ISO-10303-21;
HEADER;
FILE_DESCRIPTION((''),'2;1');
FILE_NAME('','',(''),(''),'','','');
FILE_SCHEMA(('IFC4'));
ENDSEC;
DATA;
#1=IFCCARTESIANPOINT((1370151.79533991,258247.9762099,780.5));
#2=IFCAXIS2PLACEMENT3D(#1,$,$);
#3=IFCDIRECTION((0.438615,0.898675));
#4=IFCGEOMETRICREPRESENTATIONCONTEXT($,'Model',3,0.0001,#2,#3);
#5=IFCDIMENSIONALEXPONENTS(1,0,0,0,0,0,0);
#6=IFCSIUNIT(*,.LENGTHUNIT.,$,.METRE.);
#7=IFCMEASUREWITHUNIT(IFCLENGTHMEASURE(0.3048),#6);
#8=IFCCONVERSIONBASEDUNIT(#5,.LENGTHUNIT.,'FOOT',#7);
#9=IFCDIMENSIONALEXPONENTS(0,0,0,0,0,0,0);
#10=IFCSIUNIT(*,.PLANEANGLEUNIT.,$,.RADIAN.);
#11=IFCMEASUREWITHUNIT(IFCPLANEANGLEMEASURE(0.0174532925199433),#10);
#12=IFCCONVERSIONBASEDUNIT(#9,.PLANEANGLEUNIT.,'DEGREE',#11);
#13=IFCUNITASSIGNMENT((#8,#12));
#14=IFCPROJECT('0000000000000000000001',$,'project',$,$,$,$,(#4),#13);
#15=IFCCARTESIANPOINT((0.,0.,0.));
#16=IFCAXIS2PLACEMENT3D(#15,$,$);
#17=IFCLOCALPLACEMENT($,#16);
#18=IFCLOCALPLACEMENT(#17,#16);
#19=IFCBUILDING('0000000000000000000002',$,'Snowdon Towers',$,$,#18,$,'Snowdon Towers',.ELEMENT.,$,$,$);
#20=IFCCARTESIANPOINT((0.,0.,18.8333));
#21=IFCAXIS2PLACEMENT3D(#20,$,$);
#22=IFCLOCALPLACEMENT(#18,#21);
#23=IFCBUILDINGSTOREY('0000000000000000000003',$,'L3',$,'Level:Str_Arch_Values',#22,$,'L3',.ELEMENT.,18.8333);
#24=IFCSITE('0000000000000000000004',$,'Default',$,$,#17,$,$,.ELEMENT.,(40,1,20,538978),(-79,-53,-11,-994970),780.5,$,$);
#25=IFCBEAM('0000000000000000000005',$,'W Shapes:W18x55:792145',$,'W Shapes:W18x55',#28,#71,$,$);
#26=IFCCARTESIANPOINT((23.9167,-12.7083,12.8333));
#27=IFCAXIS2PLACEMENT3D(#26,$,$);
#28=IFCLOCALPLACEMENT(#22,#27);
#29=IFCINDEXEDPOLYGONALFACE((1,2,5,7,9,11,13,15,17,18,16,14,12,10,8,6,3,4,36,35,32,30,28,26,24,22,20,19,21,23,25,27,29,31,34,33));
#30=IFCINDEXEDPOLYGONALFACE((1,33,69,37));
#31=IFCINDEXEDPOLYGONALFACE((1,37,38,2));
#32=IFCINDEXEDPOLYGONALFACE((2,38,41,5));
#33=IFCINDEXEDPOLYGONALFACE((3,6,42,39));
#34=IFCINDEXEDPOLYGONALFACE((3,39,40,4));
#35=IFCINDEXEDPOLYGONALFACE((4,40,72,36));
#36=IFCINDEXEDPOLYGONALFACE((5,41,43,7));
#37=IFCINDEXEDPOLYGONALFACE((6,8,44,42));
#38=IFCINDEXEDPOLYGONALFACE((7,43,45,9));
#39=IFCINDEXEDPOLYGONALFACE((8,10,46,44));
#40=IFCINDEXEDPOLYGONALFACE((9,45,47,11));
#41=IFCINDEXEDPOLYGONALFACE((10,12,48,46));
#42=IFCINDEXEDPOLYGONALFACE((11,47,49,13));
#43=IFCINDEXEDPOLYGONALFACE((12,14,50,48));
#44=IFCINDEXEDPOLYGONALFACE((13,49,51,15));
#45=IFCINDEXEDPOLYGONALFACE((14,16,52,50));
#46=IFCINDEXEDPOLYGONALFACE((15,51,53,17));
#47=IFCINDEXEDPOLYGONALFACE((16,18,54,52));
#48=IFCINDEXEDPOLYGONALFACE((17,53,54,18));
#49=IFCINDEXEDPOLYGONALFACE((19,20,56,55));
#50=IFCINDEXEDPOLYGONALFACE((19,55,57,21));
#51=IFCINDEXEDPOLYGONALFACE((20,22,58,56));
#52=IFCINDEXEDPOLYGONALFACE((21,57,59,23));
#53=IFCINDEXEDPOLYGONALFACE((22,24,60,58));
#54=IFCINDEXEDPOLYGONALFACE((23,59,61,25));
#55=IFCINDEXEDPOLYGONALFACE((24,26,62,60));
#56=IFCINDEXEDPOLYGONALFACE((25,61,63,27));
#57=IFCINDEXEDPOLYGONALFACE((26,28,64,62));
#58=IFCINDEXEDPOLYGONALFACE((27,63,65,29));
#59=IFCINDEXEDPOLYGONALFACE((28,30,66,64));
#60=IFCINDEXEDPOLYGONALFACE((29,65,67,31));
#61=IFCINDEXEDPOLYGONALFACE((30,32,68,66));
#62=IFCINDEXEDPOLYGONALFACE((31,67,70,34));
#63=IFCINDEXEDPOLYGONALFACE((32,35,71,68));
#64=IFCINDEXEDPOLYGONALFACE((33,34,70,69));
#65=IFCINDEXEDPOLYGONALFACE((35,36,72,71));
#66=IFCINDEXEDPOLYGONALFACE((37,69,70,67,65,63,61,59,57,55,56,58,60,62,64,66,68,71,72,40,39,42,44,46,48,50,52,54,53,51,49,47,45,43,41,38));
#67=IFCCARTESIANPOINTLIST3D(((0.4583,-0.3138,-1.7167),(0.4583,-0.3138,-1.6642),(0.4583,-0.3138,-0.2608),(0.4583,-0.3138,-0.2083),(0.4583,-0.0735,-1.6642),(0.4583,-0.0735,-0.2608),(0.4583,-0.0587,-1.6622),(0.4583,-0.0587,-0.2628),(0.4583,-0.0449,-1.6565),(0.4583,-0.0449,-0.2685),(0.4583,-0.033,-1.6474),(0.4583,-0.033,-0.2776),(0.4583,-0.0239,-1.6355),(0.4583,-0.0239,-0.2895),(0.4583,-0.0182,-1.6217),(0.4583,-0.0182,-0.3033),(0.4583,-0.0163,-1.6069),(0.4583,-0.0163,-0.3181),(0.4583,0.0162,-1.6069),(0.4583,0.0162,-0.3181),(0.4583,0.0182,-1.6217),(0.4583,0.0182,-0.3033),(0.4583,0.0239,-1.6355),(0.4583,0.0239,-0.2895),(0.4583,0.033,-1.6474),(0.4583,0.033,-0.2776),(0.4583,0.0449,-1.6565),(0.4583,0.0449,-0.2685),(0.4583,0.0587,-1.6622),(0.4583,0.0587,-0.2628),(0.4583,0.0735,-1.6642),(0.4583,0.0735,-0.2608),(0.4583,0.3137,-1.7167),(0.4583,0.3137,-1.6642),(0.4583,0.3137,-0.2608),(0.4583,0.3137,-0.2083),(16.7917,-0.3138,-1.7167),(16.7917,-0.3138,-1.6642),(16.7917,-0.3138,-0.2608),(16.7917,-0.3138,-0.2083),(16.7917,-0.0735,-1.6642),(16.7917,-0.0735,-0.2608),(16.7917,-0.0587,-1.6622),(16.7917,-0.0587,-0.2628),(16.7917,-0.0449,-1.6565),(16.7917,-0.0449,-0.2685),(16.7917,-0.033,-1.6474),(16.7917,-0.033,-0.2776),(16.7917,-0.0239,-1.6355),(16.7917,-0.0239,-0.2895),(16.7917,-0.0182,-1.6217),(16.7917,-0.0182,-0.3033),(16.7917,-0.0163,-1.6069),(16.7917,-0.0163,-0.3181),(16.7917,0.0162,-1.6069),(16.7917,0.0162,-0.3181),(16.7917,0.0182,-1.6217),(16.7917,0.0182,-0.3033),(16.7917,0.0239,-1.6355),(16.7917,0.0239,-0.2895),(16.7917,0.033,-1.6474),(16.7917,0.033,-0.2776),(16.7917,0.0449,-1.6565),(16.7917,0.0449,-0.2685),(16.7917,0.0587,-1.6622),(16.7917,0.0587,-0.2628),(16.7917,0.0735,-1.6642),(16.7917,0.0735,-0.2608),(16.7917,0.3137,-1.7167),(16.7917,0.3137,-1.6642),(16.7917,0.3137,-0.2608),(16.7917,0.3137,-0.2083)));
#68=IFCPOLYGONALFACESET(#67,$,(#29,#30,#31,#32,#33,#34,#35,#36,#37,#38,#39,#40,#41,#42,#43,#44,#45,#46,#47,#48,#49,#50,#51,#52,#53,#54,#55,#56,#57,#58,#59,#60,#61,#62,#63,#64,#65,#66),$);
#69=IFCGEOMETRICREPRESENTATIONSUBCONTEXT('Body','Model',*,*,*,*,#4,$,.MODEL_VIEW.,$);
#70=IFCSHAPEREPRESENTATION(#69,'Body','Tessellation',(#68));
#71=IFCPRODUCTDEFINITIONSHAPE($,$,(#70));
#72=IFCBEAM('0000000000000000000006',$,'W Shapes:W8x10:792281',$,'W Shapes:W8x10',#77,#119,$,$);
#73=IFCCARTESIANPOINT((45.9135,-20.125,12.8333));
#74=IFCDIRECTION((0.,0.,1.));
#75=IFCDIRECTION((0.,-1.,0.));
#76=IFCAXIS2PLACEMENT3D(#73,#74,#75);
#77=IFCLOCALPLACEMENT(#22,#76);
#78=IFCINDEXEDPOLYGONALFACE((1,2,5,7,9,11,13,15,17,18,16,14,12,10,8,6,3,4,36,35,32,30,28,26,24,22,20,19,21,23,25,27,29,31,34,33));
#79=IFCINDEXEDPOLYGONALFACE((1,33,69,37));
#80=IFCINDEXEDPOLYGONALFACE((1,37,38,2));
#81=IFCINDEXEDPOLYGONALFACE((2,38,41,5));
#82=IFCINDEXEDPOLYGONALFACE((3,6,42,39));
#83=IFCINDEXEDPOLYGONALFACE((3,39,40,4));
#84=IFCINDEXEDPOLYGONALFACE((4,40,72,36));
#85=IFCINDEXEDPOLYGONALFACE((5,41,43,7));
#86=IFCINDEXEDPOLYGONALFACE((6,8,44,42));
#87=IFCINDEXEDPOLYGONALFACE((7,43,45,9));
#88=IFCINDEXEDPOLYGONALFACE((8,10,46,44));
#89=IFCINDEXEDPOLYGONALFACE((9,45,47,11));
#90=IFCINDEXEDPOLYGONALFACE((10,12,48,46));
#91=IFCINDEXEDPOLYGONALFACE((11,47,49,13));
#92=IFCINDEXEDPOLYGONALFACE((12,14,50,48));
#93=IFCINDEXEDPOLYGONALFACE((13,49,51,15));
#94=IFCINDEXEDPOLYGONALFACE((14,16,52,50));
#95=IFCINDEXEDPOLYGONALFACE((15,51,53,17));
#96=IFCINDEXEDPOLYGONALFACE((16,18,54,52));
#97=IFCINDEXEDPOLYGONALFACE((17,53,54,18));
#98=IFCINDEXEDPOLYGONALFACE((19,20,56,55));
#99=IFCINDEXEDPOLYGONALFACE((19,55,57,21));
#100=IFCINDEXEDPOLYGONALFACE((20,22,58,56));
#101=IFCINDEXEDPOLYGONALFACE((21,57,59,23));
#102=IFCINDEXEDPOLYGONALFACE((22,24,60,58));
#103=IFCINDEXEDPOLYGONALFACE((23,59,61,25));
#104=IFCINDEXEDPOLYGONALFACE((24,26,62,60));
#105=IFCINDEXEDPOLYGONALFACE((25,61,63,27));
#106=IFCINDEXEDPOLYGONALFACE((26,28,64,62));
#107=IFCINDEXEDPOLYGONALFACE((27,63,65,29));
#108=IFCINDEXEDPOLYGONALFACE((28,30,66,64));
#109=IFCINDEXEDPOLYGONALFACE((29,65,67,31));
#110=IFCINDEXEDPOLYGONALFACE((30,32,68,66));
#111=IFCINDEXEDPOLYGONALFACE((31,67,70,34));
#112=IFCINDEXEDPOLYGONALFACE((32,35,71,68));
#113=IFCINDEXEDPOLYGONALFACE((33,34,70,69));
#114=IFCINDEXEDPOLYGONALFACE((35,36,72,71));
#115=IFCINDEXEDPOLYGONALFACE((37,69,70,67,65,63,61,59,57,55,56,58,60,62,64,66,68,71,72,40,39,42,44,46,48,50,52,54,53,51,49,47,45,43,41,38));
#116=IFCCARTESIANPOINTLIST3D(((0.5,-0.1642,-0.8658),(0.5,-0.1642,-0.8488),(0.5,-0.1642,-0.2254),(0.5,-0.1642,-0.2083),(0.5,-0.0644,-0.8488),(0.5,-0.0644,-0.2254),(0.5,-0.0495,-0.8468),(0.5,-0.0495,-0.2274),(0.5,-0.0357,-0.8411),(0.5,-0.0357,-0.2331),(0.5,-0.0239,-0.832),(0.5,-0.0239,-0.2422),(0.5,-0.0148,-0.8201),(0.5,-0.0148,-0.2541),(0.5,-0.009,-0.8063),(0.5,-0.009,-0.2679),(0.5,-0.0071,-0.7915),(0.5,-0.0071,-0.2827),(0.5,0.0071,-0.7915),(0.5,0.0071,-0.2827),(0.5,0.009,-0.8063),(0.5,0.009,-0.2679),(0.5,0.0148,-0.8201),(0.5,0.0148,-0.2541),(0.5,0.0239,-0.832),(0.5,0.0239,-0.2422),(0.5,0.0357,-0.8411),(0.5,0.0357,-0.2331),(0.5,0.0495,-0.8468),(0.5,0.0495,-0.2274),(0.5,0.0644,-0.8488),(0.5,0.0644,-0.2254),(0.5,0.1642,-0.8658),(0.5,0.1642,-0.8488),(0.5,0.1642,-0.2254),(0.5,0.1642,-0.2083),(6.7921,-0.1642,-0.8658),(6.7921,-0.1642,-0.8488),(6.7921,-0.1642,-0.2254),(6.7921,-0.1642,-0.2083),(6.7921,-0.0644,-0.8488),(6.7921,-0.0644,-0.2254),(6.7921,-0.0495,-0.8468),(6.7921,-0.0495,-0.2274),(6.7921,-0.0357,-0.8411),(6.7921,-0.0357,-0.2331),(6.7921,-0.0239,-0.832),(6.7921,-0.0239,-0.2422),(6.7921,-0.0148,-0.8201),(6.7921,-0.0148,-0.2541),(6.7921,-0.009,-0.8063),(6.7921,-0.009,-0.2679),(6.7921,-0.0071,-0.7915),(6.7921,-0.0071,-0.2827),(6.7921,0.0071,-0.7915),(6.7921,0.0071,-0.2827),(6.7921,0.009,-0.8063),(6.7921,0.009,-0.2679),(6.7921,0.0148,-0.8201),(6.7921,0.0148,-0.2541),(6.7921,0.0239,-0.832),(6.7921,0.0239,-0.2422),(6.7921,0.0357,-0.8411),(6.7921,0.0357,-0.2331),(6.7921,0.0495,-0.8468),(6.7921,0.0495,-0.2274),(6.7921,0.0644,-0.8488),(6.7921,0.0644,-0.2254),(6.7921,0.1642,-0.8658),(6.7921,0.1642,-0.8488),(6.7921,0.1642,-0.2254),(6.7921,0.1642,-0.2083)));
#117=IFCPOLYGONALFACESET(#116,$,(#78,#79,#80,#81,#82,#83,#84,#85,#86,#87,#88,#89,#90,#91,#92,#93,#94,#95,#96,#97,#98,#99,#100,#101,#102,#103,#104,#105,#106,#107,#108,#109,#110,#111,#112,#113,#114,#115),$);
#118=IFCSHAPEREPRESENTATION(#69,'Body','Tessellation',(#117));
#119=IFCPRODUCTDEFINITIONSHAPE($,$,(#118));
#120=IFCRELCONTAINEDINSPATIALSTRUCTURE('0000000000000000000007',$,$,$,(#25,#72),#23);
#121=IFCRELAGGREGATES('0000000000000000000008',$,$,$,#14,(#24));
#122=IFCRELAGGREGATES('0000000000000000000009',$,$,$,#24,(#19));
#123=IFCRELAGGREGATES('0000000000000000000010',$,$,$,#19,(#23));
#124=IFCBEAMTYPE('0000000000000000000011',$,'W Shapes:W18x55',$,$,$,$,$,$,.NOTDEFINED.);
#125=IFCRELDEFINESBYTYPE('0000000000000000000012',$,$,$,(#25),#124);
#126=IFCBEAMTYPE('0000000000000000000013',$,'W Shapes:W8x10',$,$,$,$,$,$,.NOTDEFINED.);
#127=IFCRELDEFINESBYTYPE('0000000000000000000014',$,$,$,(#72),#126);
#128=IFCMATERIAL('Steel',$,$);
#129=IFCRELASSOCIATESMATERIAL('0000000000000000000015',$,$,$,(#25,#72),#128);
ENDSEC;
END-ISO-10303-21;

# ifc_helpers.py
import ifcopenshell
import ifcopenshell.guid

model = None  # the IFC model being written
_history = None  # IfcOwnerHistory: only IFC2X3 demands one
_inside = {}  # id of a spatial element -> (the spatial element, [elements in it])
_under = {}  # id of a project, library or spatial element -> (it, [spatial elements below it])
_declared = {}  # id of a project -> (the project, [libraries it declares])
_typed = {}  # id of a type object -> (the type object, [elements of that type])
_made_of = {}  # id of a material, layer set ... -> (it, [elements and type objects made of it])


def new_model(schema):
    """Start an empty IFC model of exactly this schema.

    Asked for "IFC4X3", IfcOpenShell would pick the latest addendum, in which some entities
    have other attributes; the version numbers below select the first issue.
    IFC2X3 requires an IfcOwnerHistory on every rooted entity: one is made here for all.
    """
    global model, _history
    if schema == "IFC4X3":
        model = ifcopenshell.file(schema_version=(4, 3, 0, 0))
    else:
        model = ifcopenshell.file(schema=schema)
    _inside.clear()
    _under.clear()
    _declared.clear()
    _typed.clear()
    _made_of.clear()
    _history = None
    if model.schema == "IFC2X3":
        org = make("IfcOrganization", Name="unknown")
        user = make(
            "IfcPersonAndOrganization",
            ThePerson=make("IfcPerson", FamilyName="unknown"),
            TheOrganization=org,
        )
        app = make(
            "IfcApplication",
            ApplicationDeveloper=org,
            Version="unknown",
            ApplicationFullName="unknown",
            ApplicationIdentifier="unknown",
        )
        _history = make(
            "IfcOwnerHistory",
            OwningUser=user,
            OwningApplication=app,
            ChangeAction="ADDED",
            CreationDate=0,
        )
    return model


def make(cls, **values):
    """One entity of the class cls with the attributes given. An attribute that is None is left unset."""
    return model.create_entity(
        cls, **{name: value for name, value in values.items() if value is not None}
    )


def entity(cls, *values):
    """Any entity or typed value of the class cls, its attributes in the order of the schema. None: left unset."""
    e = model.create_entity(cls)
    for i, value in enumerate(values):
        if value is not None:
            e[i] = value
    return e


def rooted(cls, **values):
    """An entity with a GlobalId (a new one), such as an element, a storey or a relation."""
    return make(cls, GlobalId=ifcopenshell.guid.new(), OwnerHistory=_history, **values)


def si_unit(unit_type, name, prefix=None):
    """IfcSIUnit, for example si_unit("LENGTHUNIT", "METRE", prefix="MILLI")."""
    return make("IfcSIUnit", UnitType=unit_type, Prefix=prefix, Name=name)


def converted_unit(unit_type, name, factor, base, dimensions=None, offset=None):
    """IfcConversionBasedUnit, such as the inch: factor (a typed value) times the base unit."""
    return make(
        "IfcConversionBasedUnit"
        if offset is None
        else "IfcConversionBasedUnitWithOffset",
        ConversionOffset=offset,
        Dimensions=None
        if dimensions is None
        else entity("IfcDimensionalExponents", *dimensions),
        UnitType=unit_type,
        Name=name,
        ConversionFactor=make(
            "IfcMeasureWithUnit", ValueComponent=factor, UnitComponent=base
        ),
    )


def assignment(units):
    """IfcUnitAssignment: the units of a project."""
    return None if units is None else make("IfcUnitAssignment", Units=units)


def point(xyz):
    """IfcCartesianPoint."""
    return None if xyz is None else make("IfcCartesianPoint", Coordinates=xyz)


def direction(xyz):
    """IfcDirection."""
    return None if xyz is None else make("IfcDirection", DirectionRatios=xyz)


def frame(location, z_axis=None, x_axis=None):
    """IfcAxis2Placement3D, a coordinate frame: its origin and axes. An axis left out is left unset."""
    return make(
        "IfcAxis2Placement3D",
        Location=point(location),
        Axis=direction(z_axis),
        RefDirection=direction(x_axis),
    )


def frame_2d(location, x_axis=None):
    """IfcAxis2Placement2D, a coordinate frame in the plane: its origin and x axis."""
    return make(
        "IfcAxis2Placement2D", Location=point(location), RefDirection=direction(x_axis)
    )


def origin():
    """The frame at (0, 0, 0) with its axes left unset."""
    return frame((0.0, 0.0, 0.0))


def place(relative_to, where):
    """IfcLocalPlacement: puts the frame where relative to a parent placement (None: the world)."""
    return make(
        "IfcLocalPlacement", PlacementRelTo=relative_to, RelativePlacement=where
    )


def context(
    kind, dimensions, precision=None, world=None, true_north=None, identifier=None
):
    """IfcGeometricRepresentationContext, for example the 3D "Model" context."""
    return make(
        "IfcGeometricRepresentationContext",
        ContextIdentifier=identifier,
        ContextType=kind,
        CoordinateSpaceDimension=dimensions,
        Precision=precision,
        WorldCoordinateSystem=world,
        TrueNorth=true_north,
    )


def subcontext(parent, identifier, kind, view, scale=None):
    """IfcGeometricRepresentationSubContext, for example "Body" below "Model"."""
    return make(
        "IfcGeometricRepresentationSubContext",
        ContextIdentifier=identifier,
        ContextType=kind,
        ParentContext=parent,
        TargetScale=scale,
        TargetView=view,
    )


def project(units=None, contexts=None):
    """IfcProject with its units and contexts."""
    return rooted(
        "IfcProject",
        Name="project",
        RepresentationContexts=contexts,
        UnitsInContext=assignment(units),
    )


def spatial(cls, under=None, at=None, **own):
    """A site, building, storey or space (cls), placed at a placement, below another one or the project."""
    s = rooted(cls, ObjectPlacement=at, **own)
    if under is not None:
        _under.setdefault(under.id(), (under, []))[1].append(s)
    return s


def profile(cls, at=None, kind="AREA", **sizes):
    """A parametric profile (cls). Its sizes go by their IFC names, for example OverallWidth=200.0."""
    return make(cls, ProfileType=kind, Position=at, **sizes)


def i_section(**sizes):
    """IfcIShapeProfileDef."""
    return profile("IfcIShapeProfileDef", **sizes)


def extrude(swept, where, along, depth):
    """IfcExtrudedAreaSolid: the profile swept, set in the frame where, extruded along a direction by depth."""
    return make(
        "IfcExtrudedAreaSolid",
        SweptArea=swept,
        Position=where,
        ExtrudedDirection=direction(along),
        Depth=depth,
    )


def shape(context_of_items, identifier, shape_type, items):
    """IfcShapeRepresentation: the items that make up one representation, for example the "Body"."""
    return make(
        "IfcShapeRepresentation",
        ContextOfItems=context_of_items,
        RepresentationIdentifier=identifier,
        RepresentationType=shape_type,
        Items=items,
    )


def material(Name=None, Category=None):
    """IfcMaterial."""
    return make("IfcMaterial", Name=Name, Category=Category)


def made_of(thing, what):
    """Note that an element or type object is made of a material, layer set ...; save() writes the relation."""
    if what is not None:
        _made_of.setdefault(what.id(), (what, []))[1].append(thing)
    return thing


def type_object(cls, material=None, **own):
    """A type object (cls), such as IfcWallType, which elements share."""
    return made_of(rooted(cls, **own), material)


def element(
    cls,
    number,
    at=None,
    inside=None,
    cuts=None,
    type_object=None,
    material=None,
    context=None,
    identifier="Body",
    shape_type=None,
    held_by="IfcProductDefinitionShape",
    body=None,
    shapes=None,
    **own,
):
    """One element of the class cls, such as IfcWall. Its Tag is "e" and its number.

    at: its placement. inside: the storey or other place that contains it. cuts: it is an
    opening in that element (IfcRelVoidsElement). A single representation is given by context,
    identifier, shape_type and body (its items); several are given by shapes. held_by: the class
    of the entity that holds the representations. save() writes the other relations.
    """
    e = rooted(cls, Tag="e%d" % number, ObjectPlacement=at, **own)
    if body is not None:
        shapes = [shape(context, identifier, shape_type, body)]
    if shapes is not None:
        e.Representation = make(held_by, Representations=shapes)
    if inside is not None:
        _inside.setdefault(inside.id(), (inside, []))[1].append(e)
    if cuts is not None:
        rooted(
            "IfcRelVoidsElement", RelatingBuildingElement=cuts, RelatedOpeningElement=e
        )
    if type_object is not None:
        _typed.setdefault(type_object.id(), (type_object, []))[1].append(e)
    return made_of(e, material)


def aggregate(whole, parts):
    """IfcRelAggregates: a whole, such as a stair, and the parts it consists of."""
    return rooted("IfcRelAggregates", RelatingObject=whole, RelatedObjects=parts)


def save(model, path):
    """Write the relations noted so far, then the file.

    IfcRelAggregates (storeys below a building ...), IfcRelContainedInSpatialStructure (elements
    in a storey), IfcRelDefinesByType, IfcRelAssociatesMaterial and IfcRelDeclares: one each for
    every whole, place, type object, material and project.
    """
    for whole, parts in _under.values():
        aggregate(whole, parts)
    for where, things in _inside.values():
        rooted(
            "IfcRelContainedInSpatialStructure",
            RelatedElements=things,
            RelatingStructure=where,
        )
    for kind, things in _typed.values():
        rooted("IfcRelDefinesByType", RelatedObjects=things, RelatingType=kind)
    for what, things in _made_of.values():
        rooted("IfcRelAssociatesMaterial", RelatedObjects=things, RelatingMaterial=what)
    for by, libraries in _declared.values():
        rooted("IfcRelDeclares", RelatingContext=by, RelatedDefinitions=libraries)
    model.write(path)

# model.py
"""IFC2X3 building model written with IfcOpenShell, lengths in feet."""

from ifc_helpers import new_model, entity, si_unit, converted_unit, direction, frame, frame_2d, origin, place, context, subcontext, project, spatial, i_section, extrude, material, type_object, element, save


model = new_model("IFC2X3")

# Units and contexts
model_context = context("Model", 3, precision=0.0001, world=frame((1370151.79533991, 258247.9762099, 780.5)), true_north=direction((0.438615, 0.898675)))
body_context = subcontext(model_context, "Body", "Model", "MODEL_VIEW")
ifc_project = project(units=[converted_unit("LENGTHUNIT", "FOOT", entity("IfcLengthMeasure", 0.3048), si_unit("LENGTHUNIT", "METRE"), dimensions=[1, 0, 0, 0, 0, 0, 0]), converted_unit("PLANEANGLEUNIT", "DEGREE", entity("IfcPlaneAngleMeasure", 0.0174532925199433), si_unit("PLANEANGLEUNIT", "RADIAN"), dimensions=[0, 0, 0, 0, 0, 0, 0])], contexts=[model_context])

# Site, building, storey
site_placement = place(None, origin())
site = spatial("IfcSite", under=ifc_project, at=site_placement, Name="Default", CompositionType="ELEMENT", RefLatitude=(40, 1, 20, 538978), RefLongitude=(-79, -53, -11, -994970), RefElevation=780.5)
building_placement = place(site_placement, origin())
building = spatial("IfcBuilding", under=site, at=building_placement, Name="Snowdon Towers", LongName="Snowdon Towers", CompositionType="ELEMENT")
storey_placement = place(building_placement, frame((0.0, 0.0, 18.8333)))
storey = spatial("IfcBuildingStorey", under=building, at=storey_placement, Name="L3", ObjectType="Level:Str_Arch_Values", LongName="L3", CompositionType="ELEMENT", Elevation=18.8333)

# Beams
ifc_material = material(Name="Steel")
beam_type_1 = type_object("IfcBeamType", Name="W Shapes:W18x55", PredefinedType="NOTDEFINED")
beam_1_placement = place(storey_placement, frame((23.9167, -12.7083, 12.8333)))
element("IfcBeam", 1, at=beam_1_placement, inside=storey, type_object=beam_type_1, material=ifc_material, Name="W Shapes:W18x55:792145", ObjectType="W Shapes:W18x55", context=body_context, shape_type="SweptSolid", body=[
    extrude(i_section(OverallWidth=0.6275, OverallDepth=1.5083, WebThickness=0.0325, FlangeThickness=0.0525, FilletRadius=0.0573, at=frame_2d((0.0, 0.0), x_axis=(0.0, 1.0))), frame((0.4583, 0.0, -0.9625), z_axis=(1.0, 0.0, 0.0), x_axis=(0.0, 0.0, -1.0)), (0.0, 0.0, 1.0), 16.3333),
])
beam_type_2 = type_object("IfcBeamType", Name="W Shapes:W8x10", PredefinedType="NOTDEFINED")
beam_2_placement = place(storey_placement, frame((45.9135, -20.125, 12.8333), z_axis=(0.0, 0.0, 1.0), x_axis=(0.0, -1.0, 0.0)))
element("IfcBeam", 2, at=beam_2_placement, inside=storey, type_object=beam_type_2, material=ifc_material, Name="W Shapes:W8x10:792281", ObjectType="W Shapes:W8x10", context=body_context, shape_type="SweptSolid", body=[
    extrude(i_section(OverallWidth=0.3283, OverallDepth=0.6575, WebThickness=0.0142, FlangeThickness=0.0171, FilletRadius=0.0573, at=frame_2d((0.0, 0.0), x_axis=(0.0, 1.0))), frame((0.5, 0.0, -0.5371), z_axis=(1.0, 0.0, 0.0), x_axis=(0.0, 0.0, -1.0)), (0.0, 0.0, 1.0), 6.2921),
])

save(model, "model.ifc")
